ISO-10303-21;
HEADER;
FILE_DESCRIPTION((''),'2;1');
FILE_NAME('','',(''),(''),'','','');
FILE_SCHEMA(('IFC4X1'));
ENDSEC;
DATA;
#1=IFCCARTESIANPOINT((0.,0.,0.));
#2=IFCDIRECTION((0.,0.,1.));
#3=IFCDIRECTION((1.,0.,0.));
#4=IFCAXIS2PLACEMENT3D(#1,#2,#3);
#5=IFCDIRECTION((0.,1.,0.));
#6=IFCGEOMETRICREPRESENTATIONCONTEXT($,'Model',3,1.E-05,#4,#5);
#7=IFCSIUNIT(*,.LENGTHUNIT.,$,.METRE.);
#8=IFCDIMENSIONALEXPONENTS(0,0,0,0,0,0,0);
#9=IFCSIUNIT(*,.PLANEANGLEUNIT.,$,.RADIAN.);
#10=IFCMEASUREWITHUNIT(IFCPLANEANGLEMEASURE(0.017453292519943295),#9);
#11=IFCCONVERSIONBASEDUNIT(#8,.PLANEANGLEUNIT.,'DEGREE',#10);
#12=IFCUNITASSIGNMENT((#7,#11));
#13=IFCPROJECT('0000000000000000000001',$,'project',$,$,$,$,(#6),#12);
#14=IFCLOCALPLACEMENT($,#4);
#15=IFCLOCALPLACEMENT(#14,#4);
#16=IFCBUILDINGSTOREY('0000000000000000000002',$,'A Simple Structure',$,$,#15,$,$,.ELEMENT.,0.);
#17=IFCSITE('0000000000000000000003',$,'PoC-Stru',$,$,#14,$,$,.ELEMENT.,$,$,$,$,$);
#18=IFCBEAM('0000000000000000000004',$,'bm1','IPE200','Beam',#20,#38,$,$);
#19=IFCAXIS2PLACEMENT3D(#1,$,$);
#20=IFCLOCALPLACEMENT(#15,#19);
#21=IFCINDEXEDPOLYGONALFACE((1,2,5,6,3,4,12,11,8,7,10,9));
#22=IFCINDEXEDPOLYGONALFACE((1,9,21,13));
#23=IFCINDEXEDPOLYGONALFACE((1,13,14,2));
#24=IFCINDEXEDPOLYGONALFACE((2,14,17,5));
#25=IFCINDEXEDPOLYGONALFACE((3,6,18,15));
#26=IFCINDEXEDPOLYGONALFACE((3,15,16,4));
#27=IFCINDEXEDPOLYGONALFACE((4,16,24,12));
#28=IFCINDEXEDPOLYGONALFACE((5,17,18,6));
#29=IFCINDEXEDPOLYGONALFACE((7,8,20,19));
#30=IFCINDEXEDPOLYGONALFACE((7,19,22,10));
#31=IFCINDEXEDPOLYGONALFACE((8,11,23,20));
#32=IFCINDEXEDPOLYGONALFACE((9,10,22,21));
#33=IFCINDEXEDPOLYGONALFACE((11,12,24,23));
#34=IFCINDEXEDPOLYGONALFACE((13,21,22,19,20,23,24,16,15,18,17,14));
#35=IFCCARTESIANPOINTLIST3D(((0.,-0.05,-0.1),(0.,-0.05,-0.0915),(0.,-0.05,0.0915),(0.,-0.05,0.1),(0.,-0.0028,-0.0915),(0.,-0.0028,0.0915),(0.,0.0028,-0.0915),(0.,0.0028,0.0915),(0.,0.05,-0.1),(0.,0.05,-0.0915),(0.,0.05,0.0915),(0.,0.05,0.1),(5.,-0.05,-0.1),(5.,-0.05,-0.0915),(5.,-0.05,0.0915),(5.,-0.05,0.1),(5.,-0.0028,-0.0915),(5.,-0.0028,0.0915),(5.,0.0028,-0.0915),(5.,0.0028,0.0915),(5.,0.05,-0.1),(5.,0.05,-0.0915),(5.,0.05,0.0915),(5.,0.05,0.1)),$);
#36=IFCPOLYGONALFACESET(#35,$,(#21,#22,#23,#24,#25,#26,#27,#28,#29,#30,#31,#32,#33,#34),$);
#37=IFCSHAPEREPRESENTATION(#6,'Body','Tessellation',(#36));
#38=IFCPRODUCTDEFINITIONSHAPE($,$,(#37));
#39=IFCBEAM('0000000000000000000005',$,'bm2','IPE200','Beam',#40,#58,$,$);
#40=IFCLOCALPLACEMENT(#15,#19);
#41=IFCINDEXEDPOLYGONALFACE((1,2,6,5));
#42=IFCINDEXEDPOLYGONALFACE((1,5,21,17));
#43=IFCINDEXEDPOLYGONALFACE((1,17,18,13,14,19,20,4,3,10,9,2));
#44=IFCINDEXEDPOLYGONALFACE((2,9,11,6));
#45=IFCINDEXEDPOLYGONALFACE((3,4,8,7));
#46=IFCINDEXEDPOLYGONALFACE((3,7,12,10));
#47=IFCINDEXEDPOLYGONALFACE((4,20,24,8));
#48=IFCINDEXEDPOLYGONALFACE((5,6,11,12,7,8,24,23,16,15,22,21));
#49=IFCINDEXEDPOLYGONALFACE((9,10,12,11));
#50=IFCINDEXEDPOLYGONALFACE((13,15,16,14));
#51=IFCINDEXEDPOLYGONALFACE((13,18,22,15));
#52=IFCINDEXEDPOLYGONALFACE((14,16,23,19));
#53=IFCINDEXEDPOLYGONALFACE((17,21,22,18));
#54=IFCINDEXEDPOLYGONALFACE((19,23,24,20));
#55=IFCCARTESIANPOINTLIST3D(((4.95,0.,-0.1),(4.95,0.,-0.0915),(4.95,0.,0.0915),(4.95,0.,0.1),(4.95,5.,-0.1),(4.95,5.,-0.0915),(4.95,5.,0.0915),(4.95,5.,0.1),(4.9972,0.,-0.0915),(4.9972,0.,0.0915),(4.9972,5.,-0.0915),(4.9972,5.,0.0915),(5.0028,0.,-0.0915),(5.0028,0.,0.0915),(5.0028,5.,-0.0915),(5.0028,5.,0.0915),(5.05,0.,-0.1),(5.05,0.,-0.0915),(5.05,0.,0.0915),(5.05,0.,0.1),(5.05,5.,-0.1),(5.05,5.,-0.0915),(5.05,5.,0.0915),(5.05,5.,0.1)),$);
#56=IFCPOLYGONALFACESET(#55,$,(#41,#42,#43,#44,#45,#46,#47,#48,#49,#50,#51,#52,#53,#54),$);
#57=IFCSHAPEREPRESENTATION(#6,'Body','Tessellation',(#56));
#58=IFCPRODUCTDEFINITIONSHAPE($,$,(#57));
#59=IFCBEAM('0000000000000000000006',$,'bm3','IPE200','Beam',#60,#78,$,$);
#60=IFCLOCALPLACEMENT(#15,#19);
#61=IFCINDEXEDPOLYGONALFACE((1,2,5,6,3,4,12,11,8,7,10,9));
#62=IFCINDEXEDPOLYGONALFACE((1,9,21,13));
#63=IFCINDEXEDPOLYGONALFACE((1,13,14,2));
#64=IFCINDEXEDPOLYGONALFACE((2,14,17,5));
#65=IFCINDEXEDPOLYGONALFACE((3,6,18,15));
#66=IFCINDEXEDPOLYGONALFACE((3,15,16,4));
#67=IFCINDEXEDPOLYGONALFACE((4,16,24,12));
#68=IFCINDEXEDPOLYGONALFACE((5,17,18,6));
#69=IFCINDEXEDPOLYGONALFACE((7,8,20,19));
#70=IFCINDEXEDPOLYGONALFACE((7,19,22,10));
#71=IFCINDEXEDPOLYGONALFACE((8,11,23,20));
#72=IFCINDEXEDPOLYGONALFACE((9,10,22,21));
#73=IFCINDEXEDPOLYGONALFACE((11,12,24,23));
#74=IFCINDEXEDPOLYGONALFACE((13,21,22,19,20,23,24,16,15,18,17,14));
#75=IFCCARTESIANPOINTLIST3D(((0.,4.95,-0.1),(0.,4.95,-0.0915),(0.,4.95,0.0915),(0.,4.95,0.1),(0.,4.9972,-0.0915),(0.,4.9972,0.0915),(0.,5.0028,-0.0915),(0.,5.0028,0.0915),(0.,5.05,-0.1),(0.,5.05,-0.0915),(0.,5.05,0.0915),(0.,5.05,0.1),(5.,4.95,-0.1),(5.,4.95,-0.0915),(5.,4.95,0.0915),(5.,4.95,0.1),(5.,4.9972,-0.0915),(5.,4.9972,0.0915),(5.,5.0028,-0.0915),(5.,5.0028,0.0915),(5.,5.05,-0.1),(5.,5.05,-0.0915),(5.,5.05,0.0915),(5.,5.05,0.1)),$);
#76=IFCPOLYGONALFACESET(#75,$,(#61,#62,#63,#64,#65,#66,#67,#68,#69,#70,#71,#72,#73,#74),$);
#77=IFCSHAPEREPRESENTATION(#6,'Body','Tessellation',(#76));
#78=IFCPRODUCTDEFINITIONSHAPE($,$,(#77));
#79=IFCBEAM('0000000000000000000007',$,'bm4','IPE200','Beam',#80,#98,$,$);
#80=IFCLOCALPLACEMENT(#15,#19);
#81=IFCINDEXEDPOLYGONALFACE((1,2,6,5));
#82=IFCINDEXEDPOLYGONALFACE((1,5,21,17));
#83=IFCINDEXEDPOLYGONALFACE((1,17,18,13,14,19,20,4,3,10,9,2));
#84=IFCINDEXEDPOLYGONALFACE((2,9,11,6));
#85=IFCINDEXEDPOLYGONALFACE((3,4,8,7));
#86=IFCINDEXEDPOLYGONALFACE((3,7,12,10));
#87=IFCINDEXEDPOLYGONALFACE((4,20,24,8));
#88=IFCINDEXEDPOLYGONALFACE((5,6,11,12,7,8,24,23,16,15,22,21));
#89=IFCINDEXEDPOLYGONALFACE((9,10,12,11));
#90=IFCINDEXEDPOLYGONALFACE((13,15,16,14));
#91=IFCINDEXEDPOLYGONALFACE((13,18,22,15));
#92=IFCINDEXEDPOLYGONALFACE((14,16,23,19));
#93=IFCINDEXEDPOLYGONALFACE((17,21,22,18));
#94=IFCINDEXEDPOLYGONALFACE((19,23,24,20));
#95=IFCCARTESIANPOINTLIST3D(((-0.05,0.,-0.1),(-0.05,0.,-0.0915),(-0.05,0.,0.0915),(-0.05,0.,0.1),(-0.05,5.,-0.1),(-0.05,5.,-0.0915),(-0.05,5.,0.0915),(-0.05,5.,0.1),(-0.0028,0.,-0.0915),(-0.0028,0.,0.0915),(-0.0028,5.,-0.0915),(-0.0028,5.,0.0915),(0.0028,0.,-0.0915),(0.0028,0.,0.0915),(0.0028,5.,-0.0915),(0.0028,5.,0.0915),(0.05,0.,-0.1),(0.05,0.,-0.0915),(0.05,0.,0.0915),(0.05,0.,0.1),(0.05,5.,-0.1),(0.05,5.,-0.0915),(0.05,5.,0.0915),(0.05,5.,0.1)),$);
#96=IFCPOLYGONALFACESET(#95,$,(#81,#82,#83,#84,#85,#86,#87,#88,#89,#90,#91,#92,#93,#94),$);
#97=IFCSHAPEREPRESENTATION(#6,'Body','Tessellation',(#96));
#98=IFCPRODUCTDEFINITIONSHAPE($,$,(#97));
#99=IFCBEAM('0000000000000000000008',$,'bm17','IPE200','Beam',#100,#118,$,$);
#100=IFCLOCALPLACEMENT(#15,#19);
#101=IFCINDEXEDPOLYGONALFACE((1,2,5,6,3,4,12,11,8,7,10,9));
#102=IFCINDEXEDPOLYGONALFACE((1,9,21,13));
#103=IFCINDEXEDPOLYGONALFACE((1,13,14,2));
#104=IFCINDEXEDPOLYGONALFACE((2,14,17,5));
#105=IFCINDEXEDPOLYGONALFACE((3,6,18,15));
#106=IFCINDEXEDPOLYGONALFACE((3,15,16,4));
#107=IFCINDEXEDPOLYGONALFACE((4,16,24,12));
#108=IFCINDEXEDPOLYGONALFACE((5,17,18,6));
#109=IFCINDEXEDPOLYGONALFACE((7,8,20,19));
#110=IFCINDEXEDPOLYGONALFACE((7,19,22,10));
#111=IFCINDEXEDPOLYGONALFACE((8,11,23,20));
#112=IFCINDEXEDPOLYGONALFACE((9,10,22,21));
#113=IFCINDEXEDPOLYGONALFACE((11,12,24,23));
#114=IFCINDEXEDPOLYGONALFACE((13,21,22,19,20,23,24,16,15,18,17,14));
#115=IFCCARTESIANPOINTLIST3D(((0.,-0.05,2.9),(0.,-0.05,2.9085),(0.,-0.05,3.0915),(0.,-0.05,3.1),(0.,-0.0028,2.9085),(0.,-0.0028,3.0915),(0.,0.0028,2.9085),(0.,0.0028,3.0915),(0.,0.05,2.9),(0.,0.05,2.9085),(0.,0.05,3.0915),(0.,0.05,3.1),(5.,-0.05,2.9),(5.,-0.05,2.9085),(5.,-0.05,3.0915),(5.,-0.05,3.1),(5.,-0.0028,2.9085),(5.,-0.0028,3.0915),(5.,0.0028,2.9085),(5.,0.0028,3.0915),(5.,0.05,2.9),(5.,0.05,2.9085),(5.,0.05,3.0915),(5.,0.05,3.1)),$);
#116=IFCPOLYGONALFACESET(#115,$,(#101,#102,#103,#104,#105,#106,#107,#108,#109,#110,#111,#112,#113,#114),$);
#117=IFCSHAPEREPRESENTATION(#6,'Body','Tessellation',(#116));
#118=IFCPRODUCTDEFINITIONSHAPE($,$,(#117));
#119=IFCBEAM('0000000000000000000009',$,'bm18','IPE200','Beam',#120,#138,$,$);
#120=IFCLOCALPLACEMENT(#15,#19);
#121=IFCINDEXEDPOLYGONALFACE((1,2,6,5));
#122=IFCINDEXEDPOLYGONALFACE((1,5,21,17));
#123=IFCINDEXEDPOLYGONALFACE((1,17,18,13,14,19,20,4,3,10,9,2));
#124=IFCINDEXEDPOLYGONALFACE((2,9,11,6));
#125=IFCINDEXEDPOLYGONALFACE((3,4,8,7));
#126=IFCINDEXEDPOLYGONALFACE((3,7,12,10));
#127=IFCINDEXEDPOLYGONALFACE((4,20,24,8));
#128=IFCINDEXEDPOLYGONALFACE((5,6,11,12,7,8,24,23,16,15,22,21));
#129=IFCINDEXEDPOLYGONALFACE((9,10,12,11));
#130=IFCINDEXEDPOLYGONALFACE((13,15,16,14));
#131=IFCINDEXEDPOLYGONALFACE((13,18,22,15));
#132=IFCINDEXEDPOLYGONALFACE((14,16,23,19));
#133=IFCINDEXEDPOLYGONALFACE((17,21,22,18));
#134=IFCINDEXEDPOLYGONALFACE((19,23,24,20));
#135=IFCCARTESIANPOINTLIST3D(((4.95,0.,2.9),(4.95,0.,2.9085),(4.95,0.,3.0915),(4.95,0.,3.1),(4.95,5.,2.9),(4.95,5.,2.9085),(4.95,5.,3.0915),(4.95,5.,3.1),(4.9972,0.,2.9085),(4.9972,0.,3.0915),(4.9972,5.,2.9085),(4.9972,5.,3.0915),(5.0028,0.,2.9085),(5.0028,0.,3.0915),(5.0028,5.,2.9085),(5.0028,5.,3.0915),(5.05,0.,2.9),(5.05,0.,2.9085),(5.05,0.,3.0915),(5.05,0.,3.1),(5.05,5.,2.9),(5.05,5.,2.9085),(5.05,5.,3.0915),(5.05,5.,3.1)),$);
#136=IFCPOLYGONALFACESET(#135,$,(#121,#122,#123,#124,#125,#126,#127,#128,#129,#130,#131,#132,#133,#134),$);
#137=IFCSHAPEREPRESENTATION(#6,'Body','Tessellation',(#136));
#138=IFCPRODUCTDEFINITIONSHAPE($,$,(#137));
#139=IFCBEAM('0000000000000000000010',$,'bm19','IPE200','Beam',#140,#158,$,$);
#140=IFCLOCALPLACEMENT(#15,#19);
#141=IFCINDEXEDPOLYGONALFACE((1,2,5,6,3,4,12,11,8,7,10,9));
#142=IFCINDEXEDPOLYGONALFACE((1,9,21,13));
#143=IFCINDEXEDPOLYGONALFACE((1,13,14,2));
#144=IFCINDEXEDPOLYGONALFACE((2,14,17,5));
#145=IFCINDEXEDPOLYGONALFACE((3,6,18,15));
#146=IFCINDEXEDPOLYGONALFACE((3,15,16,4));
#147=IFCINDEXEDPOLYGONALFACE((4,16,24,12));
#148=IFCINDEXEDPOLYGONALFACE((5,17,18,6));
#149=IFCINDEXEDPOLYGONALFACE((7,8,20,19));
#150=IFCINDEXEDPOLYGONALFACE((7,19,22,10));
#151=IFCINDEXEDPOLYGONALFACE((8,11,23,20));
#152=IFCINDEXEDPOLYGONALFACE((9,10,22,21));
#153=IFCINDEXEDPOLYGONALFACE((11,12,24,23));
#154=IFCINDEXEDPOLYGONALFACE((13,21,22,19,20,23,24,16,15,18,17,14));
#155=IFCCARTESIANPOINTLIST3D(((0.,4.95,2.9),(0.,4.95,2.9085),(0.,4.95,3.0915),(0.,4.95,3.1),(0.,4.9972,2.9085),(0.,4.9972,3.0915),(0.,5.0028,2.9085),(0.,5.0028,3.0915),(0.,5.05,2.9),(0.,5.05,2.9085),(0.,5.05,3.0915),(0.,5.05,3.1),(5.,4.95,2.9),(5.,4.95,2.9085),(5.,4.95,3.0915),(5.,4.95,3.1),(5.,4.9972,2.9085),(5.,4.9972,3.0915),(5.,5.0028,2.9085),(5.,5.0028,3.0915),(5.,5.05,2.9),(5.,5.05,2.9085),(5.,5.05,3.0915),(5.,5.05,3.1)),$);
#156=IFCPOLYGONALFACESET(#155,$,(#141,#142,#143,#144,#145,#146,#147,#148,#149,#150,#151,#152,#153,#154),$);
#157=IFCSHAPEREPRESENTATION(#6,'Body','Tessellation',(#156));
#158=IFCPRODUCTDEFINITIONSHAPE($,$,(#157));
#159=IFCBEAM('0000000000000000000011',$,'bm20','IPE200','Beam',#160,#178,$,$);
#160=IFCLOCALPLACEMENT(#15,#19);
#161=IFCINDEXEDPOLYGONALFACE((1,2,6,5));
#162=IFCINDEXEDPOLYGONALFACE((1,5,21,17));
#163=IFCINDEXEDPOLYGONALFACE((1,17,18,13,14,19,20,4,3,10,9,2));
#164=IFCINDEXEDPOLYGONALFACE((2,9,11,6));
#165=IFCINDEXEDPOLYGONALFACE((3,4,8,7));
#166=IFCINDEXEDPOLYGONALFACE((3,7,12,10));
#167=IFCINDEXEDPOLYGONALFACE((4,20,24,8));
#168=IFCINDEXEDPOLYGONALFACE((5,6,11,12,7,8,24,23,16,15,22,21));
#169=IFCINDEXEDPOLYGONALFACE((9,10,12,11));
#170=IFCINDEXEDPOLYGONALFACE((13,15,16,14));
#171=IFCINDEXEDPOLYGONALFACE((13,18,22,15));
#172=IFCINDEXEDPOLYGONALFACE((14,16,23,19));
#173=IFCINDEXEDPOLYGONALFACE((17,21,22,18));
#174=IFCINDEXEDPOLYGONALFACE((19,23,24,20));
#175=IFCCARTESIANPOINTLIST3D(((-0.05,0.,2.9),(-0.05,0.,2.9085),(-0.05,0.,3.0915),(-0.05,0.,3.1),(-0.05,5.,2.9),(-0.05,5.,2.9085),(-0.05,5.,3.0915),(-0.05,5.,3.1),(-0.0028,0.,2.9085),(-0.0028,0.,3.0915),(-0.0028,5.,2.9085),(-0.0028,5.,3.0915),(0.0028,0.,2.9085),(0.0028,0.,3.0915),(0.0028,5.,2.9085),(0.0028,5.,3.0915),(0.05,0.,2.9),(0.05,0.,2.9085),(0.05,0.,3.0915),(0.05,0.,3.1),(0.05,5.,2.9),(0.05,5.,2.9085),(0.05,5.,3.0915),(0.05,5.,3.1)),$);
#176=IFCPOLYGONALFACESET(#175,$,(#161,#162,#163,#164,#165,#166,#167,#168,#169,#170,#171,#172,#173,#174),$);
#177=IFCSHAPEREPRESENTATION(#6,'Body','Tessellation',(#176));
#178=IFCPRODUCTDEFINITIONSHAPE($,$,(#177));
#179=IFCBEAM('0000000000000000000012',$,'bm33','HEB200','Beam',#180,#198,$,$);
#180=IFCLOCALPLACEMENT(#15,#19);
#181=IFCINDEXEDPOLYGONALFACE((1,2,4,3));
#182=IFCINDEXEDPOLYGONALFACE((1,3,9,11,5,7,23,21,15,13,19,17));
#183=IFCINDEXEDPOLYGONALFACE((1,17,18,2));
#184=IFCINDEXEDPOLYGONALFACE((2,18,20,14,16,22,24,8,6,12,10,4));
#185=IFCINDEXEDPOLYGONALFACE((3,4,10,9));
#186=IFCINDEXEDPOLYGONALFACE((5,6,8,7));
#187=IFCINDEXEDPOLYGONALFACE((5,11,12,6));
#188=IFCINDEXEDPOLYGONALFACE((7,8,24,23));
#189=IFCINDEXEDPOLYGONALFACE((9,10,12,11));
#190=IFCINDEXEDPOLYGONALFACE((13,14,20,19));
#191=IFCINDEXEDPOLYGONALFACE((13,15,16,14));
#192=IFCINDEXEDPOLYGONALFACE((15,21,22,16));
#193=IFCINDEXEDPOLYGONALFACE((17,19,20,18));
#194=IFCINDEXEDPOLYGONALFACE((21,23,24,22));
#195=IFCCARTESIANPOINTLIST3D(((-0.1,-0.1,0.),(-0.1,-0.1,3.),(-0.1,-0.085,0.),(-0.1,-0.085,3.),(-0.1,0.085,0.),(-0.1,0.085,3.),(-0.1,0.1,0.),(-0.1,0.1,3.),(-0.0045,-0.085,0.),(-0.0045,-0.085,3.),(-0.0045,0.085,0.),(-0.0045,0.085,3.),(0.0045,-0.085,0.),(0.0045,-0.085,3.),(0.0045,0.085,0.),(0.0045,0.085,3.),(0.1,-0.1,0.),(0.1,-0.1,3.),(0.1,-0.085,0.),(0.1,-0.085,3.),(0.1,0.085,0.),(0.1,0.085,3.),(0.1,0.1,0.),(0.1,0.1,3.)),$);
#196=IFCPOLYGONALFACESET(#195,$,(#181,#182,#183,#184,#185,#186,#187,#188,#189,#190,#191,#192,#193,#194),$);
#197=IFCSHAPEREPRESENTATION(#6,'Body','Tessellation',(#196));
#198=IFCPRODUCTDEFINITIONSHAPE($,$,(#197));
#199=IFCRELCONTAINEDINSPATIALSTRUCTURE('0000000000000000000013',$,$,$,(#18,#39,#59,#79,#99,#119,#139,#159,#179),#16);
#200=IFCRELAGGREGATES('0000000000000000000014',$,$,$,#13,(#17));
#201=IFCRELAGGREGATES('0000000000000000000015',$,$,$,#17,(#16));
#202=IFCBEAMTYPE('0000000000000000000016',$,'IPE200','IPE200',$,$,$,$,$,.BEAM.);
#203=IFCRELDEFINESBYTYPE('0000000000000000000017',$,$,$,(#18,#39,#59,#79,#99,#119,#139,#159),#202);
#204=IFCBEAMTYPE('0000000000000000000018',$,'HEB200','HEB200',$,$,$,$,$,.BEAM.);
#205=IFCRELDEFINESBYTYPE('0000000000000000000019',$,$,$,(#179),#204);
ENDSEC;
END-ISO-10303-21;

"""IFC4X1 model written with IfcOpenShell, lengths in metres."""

from ifc_helpers import new_model, entity, si_unit, converted_unit, direction, frame, origin, origin_with_axes, place, context, project, spatial, i_section, extrude, type_object, element, save


model = new_model("IFC4X1")

# Units and contexts
model_context = context("Model", 3, precision=1e-05, world=origin_with_axes(), true_north=direction((0.0, 1.0, 0.0)))
ifc_project = project(units=[si_unit("LENGTHUNIT", "METRE"), converted_unit("PLANEANGLEUNIT", "DEGREE", entity("IfcPlaneAngleMeasure", 0.017453292519943295), si_unit("PLANEANGLEUNIT", "RADIAN"), dimensions=[0, 0, 0, 0, 0, 0, 0])], contexts=[model_context])

# Site, storey
site_placement = place(None, origin_with_axes())
site = spatial("IfcSite", under=ifc_project, at=site_placement, Name="PoC-Stru", CompositionType="ELEMENT")
storey_placement = place(site_placement, origin_with_axes())
storey = spatial("IfcBuildingStorey", under=site, at=storey_placement, Name="A Simple Structure", CompositionType="ELEMENT", Elevation=0.0)

# Beams
beam_type_1 = type_object("IfcBeamType", Name="IPE200", Description="IPE200", PredefinedType="BEAM")
placement_1 = place(storey_placement, origin_with_axes())
beam_1_placement = place(placement_1, frame((0.0, 0.0, 0.0), z_axis=(1.0, 0.0, 0.0), x_axis=(0.0, 1.0, 0.0)))
element("IfcBeam", 1, at=beam_1_placement, inside=storey, type_object=beam_type_1, Name="bm1", Description="IPE200", ObjectType="Beam", context=model_context, shape_type="SweptSolid", body=[
    extrude(i_section(OverallWidth=0.1, OverallDepth=0.2, WebThickness=0.0056, FlangeThickness=0.0085), origin(), (0.0, 0.0, 1.0), 5.0),
])
placement_2 = place(storey_placement, origin_with_axes())
beam_2_placement = place(placement_2, frame((5.0, 0.0, 0.0), z_axis=(0.0, 1.0, 0.0), x_axis=(-1.0, 0.0, 0.0)))
element("IfcBeam", 2, at=beam_2_placement, inside=storey, type_object=beam_type_1, Name="bm2", Description="IPE200", ObjectType="Beam", context=model_context, shape_type="SweptSolid", body=[
    extrude(i_section(OverallWidth=0.1, OverallDepth=0.2, WebThickness=0.0056, FlangeThickness=0.0085), origin(), (0.0, 0.0, 1.0), 5.0),
])
placement_3 = place(storey_placement, origin_with_axes())
beam_3_placement = place(placement_3, frame((5.0, 5.0, 0.0), z_axis=(-1.0, 0.0, 0.0), x_axis=(0.0, -1.0, 0.0)))
element("IfcBeam", 3, at=beam_3_placement, inside=storey, type_object=beam_type_1, Name="bm3", Description="IPE200", ObjectType="Beam", context=model_context, shape_type="SweptSolid", body=[
    extrude(i_section(OverallWidth=0.1, OverallDepth=0.2, WebThickness=0.0056, FlangeThickness=0.0085), origin(), (0.0, 0.0, 1.0), 5.0),
])
placement_4 = place(storey_placement, origin_with_axes())
beam_4_placement = place(placement_4, frame((0.0, 5.0, 0.0), z_axis=(0.0, -1.0, 0.0), x_axis=(1.0, 0.0, 0.0)))
element("IfcBeam", 4, at=beam_4_placement, inside=storey, type_object=beam_type_1, Name="bm4", Description="IPE200", ObjectType="Beam", context=model_context, shape_type="SweptSolid", body=[
    extrude(i_section(OverallWidth=0.1, OverallDepth=0.2, WebThickness=0.0056, FlangeThickness=0.0085), origin(), (0.0, 0.0, 1.0), 5.0),
])
placement_5 = place(storey_placement, origin_with_axes())
beam_5_placement = place(placement_5, frame((0.0, 0.0, 3.0), z_axis=(1.0, 0.0, 0.0), x_axis=(0.0, 1.0, 0.0)))
element("IfcBeam", 5, at=beam_5_placement, inside=storey, type_object=beam_type_1, Name="bm17", Description="IPE200", ObjectType="Beam", context=model_context, shape_type="SweptSolid", body=[
    extrude(i_section(OverallWidth=0.1, OverallDepth=0.2, WebThickness=0.0056, FlangeThickness=0.0085), origin(), (0.0, 0.0, 1.0), 5.0),
])
placement_6 = place(storey_placement, origin_with_axes())
beam_6_placement = place(placement_6, frame((5.0, 0.0, 3.0), z_axis=(0.0, 1.0, 0.0), x_axis=(-1.0, 0.0, 0.0)))
element("IfcBeam", 6, at=beam_6_placement, inside=storey, type_object=beam_type_1, Name="bm18", Description="IPE200", ObjectType="Beam", context=model_context, shape_type="SweptSolid", body=[
    extrude(i_section(OverallWidth=0.1, OverallDepth=0.2, WebThickness=0.0056, FlangeThickness=0.0085), origin(), (0.0, 0.0, 1.0), 5.0),
])
placement_7 = place(storey_placement, origin_with_axes())
beam_7_placement = place(placement_7, frame((5.0, 5.0, 3.0), z_axis=(-1.0, 0.0, 0.0), x_axis=(0.0, -1.0, 0.0)))
element("IfcBeam", 7, at=beam_7_placement, inside=storey, type_object=beam_type_1, Name="bm19", Description="IPE200", ObjectType="Beam", context=model_context, shape_type="SweptSolid", body=[
    extrude(i_section(OverallWidth=0.1, OverallDepth=0.2, WebThickness=0.0056, FlangeThickness=0.0085), origin(), (0.0, 0.0, 1.0), 5.0),
])
placement_8 = place(storey_placement, origin_with_axes())
beam_8_placement = place(placement_8, frame((0.0, 5.0, 3.0), z_axis=(0.0, -1.0, 0.0), x_axis=(1.0, 0.0, 0.0)))
element("IfcBeam", 8, at=beam_8_placement, inside=storey, type_object=beam_type_1, Name="bm20", Description="IPE200", ObjectType="Beam", context=model_context, shape_type="SweptSolid", body=[
    extrude(i_section(OverallWidth=0.1, OverallDepth=0.2, WebThickness=0.0056, FlangeThickness=0.0085), origin(), (0.0, 0.0, 1.0), 5.0),
])
beam_type_2 = type_object("IfcBeamType", Name="HEB200", Description="HEB200", PredefinedType="BEAM")
placement_9 = place(storey_placement, origin_with_axes())
beam_9_placement = place(placement_9, origin_with_axes())
element("IfcBeam", 9, at=beam_9_placement, inside=storey, type_object=beam_type_2, Name="bm33", Description="HEB200", ObjectType="Beam", context=model_context, shape_type="SweptSolid", body=[
    extrude(i_section(OverallWidth=0.2, OverallDepth=0.2, WebThickness=0.009, FlangeThickness=0.015), origin(), (0.0, 0.0, 1.0), 3.0),
])

save(model, "model.ifc")
